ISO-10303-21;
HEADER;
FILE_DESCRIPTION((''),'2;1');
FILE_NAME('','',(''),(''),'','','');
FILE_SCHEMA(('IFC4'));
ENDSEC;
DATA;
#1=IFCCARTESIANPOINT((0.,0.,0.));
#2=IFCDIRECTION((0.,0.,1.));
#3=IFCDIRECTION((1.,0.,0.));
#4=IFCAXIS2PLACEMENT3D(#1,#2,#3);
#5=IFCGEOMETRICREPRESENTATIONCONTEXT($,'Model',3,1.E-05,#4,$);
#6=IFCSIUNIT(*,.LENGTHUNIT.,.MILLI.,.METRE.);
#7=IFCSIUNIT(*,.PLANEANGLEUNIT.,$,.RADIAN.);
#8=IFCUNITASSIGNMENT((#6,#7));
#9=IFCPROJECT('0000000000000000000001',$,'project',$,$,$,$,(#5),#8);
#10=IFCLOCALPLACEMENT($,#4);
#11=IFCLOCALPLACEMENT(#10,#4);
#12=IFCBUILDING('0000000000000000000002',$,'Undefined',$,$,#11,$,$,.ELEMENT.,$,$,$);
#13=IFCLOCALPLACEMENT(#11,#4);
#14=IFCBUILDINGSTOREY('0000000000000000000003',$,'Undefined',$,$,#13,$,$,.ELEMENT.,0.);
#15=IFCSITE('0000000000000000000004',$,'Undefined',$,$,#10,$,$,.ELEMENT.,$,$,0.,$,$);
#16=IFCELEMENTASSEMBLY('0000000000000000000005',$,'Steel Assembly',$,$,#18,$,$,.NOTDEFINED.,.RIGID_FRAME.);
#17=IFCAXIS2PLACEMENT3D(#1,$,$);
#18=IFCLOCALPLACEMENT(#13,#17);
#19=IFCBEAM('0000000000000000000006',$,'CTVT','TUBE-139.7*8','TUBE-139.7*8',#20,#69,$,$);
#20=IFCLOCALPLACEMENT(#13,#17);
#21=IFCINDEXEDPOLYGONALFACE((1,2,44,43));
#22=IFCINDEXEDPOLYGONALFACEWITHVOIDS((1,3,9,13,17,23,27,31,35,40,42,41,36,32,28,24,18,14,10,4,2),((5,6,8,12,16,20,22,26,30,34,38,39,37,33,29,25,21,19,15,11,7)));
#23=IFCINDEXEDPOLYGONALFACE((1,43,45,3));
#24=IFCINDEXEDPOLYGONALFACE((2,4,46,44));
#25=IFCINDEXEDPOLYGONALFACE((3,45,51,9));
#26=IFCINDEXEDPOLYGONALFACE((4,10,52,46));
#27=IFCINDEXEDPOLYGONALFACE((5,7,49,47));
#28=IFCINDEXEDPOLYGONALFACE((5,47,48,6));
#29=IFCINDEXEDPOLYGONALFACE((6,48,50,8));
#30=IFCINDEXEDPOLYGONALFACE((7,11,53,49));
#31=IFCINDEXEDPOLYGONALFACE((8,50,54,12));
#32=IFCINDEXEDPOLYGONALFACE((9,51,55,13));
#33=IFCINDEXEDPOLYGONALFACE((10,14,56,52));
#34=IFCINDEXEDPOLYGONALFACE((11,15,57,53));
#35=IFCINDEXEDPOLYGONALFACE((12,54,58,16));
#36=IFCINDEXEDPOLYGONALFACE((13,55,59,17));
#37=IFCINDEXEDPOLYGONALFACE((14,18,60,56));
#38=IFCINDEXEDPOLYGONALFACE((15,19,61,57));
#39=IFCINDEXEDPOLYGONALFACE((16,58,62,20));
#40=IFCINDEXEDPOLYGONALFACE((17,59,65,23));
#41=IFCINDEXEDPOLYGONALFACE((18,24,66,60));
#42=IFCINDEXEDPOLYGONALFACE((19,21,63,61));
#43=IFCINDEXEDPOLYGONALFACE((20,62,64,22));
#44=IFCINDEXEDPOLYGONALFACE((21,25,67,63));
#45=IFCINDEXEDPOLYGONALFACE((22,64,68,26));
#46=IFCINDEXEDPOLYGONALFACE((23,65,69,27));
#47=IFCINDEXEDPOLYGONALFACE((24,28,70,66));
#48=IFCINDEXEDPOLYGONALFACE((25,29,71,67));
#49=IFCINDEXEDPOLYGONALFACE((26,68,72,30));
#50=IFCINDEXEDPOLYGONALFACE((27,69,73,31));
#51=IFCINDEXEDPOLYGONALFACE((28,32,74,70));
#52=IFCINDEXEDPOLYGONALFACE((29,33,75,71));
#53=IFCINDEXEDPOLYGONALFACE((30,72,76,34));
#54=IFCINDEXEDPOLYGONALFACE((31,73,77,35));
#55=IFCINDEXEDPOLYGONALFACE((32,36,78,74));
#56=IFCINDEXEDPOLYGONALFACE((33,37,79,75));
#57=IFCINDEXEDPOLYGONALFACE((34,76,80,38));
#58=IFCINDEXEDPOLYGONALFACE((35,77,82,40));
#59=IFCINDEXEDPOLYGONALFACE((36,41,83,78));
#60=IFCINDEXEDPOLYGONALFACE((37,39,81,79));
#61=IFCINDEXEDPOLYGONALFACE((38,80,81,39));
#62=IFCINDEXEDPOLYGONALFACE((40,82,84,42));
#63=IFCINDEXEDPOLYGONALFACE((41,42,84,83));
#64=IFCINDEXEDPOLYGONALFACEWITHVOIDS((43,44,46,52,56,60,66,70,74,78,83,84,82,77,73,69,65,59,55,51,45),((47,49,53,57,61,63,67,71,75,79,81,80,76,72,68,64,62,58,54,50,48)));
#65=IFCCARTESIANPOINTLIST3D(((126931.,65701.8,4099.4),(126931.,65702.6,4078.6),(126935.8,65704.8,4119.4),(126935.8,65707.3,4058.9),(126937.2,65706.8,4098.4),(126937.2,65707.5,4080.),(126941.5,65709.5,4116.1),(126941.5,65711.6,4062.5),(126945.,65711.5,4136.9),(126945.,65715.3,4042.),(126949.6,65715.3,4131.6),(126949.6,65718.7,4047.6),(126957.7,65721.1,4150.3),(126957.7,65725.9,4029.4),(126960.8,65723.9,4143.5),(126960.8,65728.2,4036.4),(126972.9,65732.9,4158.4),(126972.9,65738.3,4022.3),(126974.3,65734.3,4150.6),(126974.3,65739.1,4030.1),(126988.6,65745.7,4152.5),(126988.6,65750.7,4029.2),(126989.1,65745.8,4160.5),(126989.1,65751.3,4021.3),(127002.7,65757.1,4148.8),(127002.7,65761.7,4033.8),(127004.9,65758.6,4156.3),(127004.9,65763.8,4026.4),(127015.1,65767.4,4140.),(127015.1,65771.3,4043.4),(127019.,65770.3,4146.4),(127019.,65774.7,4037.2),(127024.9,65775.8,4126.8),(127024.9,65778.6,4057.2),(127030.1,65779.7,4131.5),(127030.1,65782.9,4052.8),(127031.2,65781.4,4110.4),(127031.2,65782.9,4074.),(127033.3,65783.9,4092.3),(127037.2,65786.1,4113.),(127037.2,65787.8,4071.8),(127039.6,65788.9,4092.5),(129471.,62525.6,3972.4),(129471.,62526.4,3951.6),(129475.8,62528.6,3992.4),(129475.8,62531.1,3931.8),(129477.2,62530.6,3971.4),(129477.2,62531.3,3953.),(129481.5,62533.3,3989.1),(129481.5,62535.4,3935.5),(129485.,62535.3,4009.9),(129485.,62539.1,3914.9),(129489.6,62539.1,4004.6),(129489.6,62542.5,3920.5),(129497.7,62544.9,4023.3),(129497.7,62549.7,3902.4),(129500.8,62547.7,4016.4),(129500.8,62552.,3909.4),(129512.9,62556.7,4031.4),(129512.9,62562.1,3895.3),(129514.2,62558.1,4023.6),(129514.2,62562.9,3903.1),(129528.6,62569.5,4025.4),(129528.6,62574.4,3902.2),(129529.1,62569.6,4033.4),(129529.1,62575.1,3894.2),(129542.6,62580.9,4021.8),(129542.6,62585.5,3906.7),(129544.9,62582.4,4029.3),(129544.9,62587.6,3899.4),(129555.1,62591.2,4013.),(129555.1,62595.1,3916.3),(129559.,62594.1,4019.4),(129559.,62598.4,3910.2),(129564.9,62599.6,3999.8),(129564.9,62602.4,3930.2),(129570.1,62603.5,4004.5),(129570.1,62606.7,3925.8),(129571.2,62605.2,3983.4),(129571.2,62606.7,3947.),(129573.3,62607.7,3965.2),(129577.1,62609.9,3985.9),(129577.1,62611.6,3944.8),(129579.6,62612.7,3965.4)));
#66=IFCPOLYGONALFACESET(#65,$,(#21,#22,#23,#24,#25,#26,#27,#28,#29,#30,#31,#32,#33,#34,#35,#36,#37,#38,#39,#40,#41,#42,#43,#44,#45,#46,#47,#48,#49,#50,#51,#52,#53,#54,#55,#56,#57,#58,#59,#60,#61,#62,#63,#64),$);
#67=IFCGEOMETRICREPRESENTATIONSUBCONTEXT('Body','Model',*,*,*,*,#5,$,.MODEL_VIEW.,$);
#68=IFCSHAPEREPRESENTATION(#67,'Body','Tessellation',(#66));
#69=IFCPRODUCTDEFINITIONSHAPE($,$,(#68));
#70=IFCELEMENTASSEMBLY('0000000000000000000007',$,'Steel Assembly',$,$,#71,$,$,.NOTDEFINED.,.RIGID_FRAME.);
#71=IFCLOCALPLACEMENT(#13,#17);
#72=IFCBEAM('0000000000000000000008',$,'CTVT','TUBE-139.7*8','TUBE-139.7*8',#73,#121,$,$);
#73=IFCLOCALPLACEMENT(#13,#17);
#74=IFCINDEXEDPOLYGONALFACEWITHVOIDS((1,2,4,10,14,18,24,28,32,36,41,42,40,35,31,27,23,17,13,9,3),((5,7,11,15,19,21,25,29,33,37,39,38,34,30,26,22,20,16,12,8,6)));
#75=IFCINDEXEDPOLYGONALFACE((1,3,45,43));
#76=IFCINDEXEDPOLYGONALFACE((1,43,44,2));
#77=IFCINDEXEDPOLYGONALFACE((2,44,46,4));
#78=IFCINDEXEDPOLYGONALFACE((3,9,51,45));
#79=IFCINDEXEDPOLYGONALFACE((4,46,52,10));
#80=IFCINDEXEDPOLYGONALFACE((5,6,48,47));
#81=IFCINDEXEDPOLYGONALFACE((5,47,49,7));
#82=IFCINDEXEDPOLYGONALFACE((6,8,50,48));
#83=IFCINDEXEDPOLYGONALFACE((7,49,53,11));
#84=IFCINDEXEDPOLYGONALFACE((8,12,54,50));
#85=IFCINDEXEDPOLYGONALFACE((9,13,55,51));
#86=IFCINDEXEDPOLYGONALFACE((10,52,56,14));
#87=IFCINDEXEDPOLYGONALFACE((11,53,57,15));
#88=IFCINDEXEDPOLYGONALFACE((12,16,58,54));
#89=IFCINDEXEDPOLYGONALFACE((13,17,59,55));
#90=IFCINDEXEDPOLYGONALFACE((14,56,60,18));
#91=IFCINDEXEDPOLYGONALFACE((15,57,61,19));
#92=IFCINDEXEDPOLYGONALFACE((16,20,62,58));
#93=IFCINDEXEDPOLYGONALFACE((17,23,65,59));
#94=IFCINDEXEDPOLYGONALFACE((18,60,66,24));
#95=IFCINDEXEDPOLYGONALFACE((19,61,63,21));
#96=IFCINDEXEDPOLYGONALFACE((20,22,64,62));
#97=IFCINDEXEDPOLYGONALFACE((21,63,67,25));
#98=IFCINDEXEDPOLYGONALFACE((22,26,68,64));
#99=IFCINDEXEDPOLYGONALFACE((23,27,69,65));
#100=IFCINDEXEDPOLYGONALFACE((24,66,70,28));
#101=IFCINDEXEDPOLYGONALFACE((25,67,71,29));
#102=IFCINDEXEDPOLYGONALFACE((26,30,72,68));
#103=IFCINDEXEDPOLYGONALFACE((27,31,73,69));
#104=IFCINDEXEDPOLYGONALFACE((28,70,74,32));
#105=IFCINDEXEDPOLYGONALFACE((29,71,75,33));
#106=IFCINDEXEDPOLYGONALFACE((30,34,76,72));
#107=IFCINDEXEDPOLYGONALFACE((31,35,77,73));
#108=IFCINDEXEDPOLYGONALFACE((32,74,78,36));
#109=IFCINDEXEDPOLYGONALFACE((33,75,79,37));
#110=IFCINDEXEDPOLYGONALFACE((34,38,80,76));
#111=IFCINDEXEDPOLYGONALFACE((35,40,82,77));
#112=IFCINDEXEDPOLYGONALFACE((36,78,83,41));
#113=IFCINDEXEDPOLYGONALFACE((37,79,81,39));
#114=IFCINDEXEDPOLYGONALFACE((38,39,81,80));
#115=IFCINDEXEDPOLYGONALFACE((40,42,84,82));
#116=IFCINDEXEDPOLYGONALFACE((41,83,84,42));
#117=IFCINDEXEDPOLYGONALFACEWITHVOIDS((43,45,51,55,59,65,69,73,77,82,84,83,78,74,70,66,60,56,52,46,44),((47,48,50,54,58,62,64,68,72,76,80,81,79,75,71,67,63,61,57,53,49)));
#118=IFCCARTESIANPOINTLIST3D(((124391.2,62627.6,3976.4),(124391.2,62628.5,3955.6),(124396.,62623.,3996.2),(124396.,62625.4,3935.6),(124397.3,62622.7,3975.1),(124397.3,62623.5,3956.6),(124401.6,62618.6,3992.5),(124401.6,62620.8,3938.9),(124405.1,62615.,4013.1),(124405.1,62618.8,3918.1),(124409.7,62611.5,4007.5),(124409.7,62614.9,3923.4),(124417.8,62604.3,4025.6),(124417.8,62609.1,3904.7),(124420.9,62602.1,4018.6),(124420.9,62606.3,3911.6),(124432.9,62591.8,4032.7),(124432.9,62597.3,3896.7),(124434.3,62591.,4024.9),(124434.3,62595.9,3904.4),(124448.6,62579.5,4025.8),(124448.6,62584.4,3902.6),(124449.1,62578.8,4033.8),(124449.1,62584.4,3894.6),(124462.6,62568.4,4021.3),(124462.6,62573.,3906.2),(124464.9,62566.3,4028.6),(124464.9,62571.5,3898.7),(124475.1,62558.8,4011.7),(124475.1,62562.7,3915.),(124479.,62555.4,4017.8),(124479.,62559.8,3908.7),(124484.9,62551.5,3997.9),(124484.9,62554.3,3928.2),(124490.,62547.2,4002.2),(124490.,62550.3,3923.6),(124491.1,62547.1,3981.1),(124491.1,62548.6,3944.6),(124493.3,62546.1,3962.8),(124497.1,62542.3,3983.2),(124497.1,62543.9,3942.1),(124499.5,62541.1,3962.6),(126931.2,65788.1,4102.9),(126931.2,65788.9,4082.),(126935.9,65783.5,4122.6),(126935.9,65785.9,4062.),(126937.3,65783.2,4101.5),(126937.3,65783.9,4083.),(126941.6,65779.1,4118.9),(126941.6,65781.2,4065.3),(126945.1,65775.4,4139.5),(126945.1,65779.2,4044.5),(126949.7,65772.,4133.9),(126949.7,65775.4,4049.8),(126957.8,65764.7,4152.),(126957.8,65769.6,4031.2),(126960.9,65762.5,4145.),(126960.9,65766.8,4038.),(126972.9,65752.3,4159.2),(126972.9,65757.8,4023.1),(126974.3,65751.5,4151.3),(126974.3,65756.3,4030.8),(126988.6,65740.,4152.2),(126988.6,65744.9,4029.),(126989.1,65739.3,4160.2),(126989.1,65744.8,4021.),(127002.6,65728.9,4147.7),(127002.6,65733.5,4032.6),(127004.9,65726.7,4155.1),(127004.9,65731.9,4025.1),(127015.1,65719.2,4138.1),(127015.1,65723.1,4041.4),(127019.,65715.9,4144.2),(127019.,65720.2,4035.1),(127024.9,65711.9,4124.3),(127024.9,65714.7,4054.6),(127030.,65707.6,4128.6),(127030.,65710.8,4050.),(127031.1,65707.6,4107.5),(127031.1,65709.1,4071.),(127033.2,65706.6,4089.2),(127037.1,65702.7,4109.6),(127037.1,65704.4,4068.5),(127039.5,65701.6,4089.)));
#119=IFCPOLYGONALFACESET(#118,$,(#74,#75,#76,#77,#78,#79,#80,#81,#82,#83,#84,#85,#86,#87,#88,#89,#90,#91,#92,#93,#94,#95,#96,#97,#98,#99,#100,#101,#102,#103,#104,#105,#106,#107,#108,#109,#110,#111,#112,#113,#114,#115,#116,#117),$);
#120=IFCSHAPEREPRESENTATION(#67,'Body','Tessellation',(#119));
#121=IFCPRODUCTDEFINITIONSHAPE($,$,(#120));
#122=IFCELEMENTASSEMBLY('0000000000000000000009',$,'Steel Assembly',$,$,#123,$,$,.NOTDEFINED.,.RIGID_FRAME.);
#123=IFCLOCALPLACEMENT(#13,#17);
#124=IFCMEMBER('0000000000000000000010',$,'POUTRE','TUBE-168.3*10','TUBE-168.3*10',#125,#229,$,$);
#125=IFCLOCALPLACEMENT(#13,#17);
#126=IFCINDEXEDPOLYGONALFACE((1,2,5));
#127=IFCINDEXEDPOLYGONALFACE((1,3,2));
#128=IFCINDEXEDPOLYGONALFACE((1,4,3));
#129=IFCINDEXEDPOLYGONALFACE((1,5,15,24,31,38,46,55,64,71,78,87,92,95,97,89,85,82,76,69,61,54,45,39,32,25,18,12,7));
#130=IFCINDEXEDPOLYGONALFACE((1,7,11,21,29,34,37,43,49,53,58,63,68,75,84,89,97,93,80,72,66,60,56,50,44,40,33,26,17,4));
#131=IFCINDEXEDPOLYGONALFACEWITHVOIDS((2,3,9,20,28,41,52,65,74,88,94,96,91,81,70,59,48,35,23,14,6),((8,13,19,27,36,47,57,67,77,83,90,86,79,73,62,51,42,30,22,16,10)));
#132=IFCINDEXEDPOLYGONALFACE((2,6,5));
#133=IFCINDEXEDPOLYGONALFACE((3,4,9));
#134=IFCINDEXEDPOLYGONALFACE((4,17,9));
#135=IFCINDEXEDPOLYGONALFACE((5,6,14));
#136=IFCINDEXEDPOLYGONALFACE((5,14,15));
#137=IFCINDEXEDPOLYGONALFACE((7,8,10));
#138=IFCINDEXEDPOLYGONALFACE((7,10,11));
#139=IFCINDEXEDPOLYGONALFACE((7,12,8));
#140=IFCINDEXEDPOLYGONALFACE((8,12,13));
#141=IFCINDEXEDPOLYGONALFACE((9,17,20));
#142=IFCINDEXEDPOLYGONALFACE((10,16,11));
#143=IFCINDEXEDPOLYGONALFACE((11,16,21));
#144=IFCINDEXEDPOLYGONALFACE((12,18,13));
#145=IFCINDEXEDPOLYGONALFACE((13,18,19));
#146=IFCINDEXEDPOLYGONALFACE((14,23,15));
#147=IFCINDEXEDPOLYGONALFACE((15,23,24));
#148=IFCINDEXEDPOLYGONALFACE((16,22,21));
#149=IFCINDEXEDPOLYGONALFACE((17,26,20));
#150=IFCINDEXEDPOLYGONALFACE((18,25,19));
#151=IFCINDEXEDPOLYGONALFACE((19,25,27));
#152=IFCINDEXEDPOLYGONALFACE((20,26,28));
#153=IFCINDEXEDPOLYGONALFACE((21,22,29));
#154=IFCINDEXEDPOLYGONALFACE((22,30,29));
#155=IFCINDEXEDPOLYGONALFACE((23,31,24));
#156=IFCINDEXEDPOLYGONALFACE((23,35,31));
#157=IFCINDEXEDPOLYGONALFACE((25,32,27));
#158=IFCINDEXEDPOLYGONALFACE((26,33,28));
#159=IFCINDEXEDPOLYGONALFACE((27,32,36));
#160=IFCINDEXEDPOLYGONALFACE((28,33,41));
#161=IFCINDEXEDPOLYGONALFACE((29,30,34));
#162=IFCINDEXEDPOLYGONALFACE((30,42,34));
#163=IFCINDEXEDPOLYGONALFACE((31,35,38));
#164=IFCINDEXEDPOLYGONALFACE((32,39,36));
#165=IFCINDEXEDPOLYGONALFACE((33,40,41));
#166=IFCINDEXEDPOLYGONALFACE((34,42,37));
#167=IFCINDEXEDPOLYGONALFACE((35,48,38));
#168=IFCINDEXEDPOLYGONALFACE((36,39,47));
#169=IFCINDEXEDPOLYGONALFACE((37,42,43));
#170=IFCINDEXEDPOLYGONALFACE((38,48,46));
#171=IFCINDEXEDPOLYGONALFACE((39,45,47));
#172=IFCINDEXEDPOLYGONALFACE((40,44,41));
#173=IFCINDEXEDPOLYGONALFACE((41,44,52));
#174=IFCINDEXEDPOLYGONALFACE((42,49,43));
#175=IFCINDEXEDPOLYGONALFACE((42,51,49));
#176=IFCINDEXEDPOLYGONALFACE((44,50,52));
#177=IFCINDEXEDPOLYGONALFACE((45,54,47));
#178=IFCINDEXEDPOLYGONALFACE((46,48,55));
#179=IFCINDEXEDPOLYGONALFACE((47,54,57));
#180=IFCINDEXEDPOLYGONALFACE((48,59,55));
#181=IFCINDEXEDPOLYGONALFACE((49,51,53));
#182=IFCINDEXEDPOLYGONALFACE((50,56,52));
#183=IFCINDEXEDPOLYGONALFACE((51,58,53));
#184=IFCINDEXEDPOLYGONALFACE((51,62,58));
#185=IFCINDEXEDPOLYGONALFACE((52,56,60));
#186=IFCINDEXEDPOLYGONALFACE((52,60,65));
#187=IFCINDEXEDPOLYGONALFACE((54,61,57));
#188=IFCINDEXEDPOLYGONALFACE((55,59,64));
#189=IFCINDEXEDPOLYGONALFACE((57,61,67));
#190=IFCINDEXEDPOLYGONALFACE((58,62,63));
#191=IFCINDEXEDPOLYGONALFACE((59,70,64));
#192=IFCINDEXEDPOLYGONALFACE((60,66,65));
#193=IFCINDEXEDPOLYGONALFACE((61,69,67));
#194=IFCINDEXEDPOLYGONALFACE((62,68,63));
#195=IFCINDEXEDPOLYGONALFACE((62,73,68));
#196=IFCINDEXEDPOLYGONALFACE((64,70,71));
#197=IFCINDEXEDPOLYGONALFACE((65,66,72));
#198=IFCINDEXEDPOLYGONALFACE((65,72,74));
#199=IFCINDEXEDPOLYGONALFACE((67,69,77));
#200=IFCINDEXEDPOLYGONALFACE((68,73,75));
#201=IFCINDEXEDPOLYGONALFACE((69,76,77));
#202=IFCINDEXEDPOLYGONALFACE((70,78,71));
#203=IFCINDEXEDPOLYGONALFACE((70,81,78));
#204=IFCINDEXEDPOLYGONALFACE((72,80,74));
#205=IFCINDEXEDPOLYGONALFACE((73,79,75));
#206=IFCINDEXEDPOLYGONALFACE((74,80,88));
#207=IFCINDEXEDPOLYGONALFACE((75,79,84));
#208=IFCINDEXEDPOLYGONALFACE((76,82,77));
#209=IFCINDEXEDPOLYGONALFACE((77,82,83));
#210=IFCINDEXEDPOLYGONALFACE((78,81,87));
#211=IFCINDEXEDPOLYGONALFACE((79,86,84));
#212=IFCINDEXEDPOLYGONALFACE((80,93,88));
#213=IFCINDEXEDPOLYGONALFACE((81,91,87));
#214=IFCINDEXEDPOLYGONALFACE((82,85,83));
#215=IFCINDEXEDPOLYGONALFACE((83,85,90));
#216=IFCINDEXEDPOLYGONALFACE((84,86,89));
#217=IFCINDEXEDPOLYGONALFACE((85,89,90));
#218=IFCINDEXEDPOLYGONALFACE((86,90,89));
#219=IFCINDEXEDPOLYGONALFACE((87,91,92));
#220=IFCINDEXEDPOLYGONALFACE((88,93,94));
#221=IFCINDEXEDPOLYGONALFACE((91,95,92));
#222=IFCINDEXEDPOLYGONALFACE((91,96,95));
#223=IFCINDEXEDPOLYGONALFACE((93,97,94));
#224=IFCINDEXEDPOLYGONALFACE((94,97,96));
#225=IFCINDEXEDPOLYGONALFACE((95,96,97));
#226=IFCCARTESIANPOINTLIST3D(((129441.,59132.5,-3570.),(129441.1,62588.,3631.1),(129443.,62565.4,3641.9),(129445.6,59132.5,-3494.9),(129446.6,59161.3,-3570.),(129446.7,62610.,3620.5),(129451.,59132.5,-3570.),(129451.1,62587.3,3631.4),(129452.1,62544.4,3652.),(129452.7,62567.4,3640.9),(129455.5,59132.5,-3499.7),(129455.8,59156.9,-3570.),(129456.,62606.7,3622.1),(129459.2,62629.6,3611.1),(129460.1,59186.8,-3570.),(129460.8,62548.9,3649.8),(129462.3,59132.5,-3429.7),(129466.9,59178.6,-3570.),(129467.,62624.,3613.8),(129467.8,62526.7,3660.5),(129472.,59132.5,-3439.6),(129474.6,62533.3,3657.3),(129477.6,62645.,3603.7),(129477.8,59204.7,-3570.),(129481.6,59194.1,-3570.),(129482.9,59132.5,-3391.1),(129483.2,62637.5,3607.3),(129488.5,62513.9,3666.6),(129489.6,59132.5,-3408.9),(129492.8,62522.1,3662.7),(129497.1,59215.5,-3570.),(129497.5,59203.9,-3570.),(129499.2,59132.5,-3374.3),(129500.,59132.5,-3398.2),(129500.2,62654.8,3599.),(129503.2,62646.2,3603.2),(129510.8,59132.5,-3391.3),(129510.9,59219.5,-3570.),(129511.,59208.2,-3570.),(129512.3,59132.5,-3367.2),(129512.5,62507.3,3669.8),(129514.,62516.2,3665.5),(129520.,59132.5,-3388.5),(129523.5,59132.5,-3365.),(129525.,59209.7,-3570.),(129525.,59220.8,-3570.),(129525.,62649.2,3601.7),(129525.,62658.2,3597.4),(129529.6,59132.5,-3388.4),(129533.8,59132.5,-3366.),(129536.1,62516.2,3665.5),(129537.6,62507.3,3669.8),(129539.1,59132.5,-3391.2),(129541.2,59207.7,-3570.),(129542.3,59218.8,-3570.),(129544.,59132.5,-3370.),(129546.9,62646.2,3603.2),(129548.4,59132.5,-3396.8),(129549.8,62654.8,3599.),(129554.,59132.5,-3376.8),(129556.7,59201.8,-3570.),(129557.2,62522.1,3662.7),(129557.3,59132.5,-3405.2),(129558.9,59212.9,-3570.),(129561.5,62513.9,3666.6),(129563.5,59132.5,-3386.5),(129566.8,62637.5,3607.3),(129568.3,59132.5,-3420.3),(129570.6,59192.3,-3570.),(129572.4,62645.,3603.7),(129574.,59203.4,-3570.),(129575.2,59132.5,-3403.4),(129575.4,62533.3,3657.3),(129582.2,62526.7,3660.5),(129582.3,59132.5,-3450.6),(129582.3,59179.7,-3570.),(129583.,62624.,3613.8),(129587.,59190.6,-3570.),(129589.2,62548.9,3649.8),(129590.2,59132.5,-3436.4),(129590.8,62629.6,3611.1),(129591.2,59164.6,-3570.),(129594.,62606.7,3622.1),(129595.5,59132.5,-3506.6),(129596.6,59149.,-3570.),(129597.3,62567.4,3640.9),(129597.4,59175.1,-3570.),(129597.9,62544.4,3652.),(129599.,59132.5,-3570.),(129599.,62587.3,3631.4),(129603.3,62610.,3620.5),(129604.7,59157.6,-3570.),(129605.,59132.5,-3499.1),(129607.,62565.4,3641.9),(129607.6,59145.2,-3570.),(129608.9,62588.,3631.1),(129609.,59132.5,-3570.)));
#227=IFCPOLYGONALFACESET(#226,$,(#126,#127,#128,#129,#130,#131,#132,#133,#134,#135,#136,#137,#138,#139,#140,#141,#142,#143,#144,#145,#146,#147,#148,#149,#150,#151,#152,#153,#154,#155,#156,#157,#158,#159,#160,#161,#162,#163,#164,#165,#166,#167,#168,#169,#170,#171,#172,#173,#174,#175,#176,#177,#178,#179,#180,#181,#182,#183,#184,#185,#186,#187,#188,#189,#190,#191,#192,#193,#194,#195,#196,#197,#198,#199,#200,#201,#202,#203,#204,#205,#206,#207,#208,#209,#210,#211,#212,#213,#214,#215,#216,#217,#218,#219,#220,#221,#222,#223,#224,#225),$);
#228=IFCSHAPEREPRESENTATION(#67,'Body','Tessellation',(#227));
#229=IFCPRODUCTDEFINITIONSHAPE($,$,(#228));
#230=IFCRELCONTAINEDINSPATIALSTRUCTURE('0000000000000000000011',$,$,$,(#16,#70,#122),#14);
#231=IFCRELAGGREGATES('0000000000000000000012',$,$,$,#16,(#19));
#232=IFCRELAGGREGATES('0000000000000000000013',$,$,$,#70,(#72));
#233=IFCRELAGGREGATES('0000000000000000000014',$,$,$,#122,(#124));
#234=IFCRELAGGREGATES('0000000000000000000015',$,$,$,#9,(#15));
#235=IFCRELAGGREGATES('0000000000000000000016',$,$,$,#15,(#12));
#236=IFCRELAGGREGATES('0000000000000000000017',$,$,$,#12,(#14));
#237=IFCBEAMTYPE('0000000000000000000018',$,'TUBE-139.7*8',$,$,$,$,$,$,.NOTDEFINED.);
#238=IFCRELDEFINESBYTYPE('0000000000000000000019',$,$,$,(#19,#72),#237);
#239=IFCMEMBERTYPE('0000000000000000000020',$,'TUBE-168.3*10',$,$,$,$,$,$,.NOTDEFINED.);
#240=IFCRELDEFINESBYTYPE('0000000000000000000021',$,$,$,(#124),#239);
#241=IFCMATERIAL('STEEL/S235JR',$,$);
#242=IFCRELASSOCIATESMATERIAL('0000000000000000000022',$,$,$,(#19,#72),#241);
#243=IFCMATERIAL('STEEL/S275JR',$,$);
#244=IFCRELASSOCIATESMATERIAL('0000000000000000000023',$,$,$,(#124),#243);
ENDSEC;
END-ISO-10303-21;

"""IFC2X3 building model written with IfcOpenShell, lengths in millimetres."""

from ifc_helpers import new_model, si_unit, frame, origin_with_axes, origin_2d_with_axis, place, context, subcontext, project, spatial, hollow_circle, extrude, clip, halfspace, material, type_object, element, aggregate, save


model = new_model("IFC2X3")

# Units and contexts
model_context = context("Model", 3, precision=1e-05, world=origin_with_axes())
body_context = subcontext(model_context, "Body", "Model", "MODEL_VIEW")
ifc_project = project(units=[si_unit("LENGTHUNIT", "METRE", prefix="MILLI"), si_unit("PLANEANGLEUNIT", "RADIAN")], contexts=[model_context])

# Site, building, storey
site_placement = place(None, origin_with_axes())
site = spatial("IfcSite", under=ifc_project, at=site_placement, Name="Undefined", CompositionType="ELEMENT", RefElevation=0.0)
building_placement = place(site_placement, origin_with_axes())
building = spatial("IfcBuilding", under=site, at=building_placement, Name="Undefined", CompositionType="ELEMENT")
storey_placement = place(building_placement, origin_with_axes())
storey = spatial("IfcBuildingStorey", under=building, at=storey_placement, Name="Undefined", CompositionType="ELEMENT", Elevation=0.0)

# Element assemblies, beams
ifc_material_1 = material(Name="STEEL/S275JR")
ifc_material_2 = material(Name="STEEL/S235JR")
beam_type_1 = type_object("IfcBeamType", Name="TUBE-139.7*8", PredefinedType="NOTDEFINED")
assembly_1_placement = place(storey_placement, origin_with_axes())
assembly_1 = element("IfcElementAssembly", 1, at=assembly_1_placement, inside=storey, Name="Steel Assembly", AssemblyPlace="NOTDEFINED", PredefinedType="RIGID_FRAME")
beam_1_placement = place(assembly_1_placement, frame((129525.0, 62569.1, 3963.7), z_axis=(-0.000001, -0.039961, 0.999201), x_axis=(-0.624244, 0.780605, 0.031218)))
beam_1 = element("IfcBeam", 2, at=beam_1_placement, type_object=beam_type_1, material=ifc_material_2, Name="CTVT", Description="TUBE-139.7*8", ObjectType="TUBE-139.7*8", context=body_context, shape_type="SweptSolid", body=[
    extrude(hollow_circle(Radius=69.8, WallThickness=8.0, at=origin_2d_with_axis()), frame((4068.9, 0.0, 0.0), z_axis=(-1.0, 0.0, 0.0), x_axis=(0.0, -1.0, 0.0)), (0.0, 0.0, 1.0), 4068.9),
])
aggregate(assembly_1, [beam_1])
assembly_2_placement = place(storey_placement, origin_with_axes())
assembly_2 = element("IfcElementAssembly", 3, at=assembly_2_placement, inside=storey, Name="Steel Assembly", AssemblyPlace="NOTDEFINED", PredefinedType="RIGID_FRAME")
beam_2_placement = place(assembly_2_placement, frame((124445.0, 62584.8, 3964.3), z_axis=(-0.000002, -0.039963, 0.999201), x_axis=(0.626136, 0.779091, 0.031161)))
beam_2 = element("IfcBeam", 4, at=beam_2_placement, type_object=beam_type_1, material=ifc_material_2, Name="CTVT", Description="TUBE-139.7*8", ObjectType="TUBE-139.7*8", context=body_context, shape_type="SweptSolid", body=[
    extrude(hollow_circle(Radius=69.8, WallThickness=8.0, at=origin_2d_with_axis()), frame((4056.6, 0.0, 0.0), z_axis=(-1.0, 0.0, 0.0), x_axis=(0.0, -1.0, 0.0)), (0.0, 0.0, 1.0), 4056.6),
])
aggregate(assembly_2, [beam_2])

# Element assembly, member
assembly_3_placement = place(storey_placement, origin_with_axes())
assembly_3 = element("IfcElementAssembly", 5, at=assembly_3_placement, inside=storey, Name="Steel Assembly", AssemblyPlace="NOTDEFINED", PredefinedType="RIGID_FRAME")
member_type = type_object("IfcMemberType", Name="TUBE-168.3*10", PredefinedType="NOTDEFINED")
member_placement = place(assembly_3_placement, frame((129525.0, 62582.3, 3633.8), z_axis=(-1.0, 0.0, 0.0), x_axis=(0.0, -0.432427, -0.901669)))
member = element("IfcMember", 6, at=member_placement, type_object=member_type, material=ifc_material_1, Name="POUTRE", Description="TUBE-168.3*10", ObjectType="TUBE-168.3*10", context=body_context, shape_type="Clipping", body=[
    clip(clip(extrude(hollow_circle(Radius=84.2, WallThickness=10.0, at=origin_2d_with_axis()), frame((8053.6, 0.0, 0.0), z_axis=(-1.0, 0.0, 0.0), x_axis=(0.0, -1.0, 0.0)), (0.0, 0.0, 1.0), 8053.6), halfspace(frame((8029.7, 84.2, 84.2), z_axis=(0.901669, -0.432427, 0.0), x_axis=(0.0, 0.0, -1.0)), False)), halfspace(frame((7968.0, 4.7, 0.0), z_axis=(-0.432427, -0.901669, 0.0), x_axis=(0.0, 0.0, -1.0)), True)),
])
aggregate(assembly_3, [member])

save(model, "model.ifc")
